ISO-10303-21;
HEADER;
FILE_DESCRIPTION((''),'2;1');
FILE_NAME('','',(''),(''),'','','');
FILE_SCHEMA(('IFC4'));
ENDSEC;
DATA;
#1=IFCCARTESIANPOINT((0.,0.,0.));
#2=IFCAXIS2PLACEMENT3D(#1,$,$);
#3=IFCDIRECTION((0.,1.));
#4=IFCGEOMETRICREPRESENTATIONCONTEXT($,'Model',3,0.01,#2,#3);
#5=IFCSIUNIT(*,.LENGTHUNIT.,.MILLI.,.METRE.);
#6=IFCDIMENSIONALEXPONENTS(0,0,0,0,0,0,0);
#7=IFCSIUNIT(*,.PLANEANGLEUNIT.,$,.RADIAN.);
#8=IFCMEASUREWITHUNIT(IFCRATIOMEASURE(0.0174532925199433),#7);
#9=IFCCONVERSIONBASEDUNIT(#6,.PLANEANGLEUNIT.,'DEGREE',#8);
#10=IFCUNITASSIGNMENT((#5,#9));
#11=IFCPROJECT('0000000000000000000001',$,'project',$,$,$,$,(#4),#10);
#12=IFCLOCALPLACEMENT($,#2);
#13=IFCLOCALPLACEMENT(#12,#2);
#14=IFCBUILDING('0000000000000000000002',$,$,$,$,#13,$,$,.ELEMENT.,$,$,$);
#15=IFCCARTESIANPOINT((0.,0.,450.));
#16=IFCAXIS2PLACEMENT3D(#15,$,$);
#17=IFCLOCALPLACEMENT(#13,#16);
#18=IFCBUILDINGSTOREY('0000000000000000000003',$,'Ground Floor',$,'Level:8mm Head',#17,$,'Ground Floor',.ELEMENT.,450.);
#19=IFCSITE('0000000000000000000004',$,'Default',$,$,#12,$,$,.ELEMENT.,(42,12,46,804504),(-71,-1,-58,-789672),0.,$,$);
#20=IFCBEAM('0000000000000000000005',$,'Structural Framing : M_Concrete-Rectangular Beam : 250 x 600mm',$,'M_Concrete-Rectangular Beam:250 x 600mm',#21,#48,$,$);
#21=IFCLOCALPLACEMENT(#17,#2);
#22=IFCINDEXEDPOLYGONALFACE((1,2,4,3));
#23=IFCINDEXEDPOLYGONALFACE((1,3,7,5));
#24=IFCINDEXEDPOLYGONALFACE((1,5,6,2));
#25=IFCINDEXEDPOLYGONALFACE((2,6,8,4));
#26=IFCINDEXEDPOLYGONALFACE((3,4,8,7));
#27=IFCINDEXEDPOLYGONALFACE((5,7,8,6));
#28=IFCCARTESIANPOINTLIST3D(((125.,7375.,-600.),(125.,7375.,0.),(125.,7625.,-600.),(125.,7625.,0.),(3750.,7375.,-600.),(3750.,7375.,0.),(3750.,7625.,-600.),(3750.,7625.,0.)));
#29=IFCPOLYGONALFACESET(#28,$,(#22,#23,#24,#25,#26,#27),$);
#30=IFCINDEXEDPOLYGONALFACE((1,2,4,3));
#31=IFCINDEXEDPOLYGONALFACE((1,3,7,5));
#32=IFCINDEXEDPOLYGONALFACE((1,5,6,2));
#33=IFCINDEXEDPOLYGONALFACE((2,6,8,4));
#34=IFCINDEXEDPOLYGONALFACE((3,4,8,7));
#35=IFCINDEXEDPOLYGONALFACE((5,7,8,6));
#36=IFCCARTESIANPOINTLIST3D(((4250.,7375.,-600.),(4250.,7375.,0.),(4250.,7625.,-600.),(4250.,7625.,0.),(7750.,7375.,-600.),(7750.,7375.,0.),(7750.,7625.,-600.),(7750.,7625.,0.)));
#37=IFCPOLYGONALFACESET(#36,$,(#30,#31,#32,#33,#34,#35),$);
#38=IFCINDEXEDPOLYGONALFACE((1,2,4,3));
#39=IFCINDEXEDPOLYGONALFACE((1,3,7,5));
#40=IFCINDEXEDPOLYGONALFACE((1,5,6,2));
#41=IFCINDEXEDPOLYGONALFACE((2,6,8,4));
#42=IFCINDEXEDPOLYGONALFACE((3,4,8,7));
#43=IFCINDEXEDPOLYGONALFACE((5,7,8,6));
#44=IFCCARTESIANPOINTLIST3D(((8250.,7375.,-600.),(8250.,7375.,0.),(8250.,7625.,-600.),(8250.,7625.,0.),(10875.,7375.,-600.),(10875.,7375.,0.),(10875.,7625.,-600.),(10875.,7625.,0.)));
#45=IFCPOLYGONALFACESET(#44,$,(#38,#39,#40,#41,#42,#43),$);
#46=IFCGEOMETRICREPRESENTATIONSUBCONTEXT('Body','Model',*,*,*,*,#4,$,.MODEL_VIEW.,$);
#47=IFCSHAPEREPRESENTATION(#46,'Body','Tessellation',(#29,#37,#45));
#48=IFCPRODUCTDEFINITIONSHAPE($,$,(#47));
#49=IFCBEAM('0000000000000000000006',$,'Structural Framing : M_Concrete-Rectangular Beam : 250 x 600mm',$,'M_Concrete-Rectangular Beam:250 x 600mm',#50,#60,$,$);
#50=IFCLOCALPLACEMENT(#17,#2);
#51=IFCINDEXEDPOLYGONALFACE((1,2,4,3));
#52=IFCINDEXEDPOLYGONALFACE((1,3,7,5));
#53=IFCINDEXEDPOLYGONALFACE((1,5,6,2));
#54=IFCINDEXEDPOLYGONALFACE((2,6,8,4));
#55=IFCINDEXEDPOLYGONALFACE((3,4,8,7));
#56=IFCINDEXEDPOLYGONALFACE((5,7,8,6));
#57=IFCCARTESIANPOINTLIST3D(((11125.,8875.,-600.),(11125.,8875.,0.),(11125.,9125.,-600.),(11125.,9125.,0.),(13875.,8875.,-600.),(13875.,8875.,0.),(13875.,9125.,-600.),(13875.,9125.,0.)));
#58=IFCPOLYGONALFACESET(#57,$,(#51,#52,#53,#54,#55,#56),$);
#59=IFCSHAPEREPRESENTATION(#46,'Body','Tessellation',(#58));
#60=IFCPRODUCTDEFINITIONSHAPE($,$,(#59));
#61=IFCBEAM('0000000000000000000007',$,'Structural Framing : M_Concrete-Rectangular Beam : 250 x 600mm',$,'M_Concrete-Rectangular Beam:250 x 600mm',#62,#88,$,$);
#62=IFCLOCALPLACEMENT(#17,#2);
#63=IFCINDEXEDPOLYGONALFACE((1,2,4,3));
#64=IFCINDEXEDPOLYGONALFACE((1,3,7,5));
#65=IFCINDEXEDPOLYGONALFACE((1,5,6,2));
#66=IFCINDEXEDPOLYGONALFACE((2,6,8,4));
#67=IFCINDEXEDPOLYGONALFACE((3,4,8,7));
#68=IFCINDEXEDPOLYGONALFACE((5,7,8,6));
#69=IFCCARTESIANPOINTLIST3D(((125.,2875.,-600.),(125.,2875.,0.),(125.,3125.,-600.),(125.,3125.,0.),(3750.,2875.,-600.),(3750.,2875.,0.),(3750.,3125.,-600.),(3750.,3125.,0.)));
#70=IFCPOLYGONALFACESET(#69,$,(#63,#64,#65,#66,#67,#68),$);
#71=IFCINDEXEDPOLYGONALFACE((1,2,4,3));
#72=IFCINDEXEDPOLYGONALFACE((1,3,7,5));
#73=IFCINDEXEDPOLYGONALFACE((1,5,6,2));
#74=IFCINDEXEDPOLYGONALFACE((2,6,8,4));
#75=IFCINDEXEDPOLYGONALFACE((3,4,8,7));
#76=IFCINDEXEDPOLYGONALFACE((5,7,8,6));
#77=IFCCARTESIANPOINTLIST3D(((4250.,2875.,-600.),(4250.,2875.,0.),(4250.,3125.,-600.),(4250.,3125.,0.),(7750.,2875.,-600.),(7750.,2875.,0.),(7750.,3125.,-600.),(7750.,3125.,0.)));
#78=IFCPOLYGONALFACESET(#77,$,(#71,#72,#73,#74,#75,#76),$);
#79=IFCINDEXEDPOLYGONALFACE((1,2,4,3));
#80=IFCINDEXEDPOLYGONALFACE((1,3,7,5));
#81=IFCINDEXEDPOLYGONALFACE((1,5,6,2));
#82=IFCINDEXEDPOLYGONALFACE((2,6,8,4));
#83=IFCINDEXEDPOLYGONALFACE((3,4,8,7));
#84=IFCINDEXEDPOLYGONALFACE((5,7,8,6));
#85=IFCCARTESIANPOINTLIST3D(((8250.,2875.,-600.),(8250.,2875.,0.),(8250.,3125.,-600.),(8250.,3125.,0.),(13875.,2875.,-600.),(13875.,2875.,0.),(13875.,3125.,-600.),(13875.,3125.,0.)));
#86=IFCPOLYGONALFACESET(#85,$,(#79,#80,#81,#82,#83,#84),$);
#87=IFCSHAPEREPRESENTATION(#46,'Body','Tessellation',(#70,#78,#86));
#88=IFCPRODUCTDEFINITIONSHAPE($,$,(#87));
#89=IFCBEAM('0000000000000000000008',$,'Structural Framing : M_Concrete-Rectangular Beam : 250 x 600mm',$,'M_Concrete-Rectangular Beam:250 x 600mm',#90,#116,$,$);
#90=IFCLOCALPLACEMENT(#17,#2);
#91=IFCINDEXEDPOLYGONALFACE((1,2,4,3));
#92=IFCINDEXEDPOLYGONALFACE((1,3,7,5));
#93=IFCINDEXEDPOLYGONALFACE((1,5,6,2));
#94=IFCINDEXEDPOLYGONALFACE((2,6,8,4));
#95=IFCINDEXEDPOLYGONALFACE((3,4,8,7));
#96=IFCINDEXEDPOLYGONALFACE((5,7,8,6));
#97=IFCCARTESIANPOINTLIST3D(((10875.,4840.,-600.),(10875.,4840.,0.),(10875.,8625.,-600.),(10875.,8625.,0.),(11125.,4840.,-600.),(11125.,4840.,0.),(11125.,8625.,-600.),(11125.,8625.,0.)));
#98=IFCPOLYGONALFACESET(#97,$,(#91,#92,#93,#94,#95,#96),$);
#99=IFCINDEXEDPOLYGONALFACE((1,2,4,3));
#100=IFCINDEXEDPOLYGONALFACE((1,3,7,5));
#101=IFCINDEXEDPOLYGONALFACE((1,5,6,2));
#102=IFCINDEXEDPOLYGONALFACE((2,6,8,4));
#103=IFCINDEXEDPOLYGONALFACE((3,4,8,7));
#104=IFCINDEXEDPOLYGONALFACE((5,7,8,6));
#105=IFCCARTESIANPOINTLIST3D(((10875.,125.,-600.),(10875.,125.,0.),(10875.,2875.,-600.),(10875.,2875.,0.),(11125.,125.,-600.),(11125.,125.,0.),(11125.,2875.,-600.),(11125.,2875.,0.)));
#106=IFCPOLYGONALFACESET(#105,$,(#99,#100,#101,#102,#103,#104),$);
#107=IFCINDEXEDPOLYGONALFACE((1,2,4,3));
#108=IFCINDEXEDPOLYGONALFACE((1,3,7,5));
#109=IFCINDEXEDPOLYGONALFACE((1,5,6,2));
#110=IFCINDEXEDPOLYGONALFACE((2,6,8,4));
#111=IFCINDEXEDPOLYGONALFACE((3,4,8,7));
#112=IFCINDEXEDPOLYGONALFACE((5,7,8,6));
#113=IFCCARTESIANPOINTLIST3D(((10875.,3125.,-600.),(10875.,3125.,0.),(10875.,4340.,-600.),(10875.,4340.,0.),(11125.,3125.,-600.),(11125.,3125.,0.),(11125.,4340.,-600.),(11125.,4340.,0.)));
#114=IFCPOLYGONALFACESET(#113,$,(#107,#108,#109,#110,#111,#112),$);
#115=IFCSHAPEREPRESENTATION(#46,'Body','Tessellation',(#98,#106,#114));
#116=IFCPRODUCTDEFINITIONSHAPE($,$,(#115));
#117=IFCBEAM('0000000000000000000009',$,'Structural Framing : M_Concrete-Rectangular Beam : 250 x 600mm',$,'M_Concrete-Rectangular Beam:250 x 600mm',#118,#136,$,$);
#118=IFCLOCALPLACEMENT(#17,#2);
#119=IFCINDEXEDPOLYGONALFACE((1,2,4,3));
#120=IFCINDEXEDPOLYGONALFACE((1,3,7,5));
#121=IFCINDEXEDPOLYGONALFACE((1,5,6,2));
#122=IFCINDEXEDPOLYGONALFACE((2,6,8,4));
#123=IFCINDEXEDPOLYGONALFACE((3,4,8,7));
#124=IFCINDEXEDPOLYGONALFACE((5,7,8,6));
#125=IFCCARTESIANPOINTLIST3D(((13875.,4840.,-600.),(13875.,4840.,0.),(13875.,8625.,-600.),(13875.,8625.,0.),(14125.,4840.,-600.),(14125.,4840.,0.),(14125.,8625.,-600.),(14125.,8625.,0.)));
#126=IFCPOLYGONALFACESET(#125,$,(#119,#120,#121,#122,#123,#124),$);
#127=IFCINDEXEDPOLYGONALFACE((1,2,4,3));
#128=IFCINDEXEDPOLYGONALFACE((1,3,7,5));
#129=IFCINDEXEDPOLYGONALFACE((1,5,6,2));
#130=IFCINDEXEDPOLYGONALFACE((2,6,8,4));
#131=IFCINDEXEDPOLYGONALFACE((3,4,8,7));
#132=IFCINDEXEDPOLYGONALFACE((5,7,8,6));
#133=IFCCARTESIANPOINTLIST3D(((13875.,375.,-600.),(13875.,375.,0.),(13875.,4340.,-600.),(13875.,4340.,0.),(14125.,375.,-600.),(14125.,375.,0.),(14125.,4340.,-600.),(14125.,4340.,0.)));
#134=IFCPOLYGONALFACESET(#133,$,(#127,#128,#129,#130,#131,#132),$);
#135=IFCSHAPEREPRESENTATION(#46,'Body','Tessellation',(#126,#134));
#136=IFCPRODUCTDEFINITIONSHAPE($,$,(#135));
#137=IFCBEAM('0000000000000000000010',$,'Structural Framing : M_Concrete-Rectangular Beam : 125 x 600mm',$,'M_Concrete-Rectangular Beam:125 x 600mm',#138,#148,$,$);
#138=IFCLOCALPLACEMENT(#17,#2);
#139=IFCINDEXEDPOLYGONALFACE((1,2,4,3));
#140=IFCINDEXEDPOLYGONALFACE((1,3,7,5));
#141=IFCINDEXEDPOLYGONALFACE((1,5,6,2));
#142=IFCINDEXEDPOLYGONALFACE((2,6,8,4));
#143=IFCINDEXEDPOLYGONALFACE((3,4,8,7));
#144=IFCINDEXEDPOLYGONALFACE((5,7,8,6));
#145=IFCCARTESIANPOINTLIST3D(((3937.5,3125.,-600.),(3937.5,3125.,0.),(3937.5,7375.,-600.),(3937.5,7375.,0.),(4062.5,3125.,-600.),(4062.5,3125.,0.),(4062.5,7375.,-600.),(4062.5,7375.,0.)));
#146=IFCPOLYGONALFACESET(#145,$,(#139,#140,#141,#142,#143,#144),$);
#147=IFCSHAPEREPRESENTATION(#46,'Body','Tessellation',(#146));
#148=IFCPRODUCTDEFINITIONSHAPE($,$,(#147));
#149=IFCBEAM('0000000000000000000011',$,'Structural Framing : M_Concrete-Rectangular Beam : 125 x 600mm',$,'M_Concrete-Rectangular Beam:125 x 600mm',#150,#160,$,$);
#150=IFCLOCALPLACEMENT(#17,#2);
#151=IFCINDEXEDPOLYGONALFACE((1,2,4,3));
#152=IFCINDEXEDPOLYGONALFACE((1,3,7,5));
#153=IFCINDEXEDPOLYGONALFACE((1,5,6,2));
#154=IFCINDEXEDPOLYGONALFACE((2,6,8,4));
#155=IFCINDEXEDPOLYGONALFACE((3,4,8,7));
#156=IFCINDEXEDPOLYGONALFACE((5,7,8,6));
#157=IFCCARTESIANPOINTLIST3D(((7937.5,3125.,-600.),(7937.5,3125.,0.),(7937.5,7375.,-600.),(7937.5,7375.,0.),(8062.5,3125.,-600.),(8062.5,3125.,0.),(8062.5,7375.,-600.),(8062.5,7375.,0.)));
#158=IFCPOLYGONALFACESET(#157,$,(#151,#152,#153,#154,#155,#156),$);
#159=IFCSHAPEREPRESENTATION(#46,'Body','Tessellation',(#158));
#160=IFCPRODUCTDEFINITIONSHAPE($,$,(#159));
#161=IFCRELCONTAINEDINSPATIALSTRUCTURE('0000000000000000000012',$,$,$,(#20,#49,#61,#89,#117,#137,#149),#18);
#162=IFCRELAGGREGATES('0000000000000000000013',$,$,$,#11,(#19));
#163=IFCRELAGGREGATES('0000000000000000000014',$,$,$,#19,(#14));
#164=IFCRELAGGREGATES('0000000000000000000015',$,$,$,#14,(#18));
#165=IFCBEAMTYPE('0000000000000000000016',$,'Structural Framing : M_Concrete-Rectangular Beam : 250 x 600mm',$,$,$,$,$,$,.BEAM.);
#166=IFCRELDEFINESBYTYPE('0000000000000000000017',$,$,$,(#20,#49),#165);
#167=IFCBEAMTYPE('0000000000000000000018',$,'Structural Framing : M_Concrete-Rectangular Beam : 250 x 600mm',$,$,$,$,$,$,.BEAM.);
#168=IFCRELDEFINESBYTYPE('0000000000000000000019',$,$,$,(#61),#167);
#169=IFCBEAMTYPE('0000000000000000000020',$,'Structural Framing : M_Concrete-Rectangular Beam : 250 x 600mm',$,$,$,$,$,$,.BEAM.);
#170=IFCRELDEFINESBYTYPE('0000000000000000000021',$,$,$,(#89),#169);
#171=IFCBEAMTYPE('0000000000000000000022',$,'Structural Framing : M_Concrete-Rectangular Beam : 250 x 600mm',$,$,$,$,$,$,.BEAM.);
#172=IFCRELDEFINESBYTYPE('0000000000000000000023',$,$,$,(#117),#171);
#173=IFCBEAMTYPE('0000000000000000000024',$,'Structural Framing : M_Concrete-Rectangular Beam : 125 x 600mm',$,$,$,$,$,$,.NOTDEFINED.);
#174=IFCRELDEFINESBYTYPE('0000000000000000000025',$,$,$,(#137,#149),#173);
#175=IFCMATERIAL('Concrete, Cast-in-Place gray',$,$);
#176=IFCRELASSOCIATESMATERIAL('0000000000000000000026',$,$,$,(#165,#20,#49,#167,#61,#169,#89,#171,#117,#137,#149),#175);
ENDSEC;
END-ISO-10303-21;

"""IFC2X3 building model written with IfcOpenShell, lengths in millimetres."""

from ifc_helpers import new_model, entity, si_unit, converted_unit, direction, frame, frame_2d, origin, place, context, subcontext, project, spatial, rectangle, extrude, source, transform, mapped, material, type_object, type_shapes, element, save


model = new_model("IFC2X3")

# Units and contexts
model_context = context("Model", 3, precision=0.01, world=origin(), true_north=direction((0.0, 1.0)))
body_context = subcontext(model_context, "Body", "Model", "MODEL_VIEW")
ifc_project = project(units=[si_unit("LENGTHUNIT", "METRE", prefix="MILLI"), converted_unit("PLANEANGLEUNIT", "DEGREE", entity("IfcRatioMeasure", 0.0174532925199433), si_unit("PLANEANGLEUNIT", "RADIAN"), dimensions=[0, 0, 0, 0, 0, 0, 0])], contexts=[model_context])

# Site, building, storey
site_placement = place(None, origin())
site = spatial("IfcSite", under=ifc_project, at=site_placement, Name="Default", CompositionType="ELEMENT", RefLatitude=(42, 12, 46, 804504), RefLongitude=(-71, -1, -58, -789672), RefElevation=0.0)
building_placement = place(site_placement, origin())
building = spatial("IfcBuilding", under=site, at=building_placement, CompositionType="ELEMENT")
storey_placement = place(building_placement, frame((0.0, 0.0, 450.0)))
storey = spatial("IfcBuildingStorey", under=building, at=storey_placement, Name="Ground Floor", ObjectType="Level:8mm Head", LongName="Ground Floor", CompositionType="ELEMENT", Elevation=450.0)

# Shared definitions
ifc_material = material(Name="Concrete, Cast-in-Place gray")

# Beams
beam_type_1 = type_object("IfcBeamType", Name="Structural Framing : M_Concrete-Rectangular Beam : 250 x 600mm", PredefinedType="BEAM", material=ifc_material)
shared_shape_1 = source(origin(), body_context, "Body", "SweptSolid", [
    extrude(rectangle(XDim=600.0, YDim=250.0, at=frame_2d((0.0, 0.0), x_axis=(1.0, 0.0))), frame((125.0, 7500.0, 150.0), z_axis=(1.0, 0.0, 0.0), x_axis=(0.0, 0.0, -1.0)), (0.0, 0.0, 1.0), 3625.0),
    extrude(rectangle(XDim=600.0, YDim=250.0, at=frame_2d((0.0, 0.0), x_axis=(1.0, 0.0))), frame((4250.0, 7500.0, 150.0), z_axis=(1.0, 0.0, 0.0), x_axis=(0.0, 0.0, -1.0)), (0.0, 0.0, 1.0), 3500.0),
    extrude(rectangle(XDim=600.0, YDim=250.0, at=frame_2d((0.0, 0.0), x_axis=(1.0, 0.0))), frame((8250.0, 7500.0, 150.0), z_axis=(1.0, 0.0, 0.0), x_axis=(0.0, 0.0, -1.0)), (0.0, 0.0, 1.0), 2625.0),
])
type_shapes(beam_type_1, [shared_shape_1])
beam_1_placement = place(storey_placement, frame((0.0, 0.0, -450.0)))
element("IfcBeam", 1, at=beam_1_placement, inside=storey, type_object=beam_type_1, material=ifc_material, Name="Structural Framing : M_Concrete-Rectangular Beam : 250 x 600mm", ObjectType="M_Concrete-Rectangular Beam:250 x 600mm", context=body_context, shape_type="MappedRepresentation", body=[
    mapped(shared_shape_1, transform((0.0, 0.0, 0.0), scale=1.0)),
])
beam_2_placement = place(storey_placement, frame((11000.0, 9000.0, 0.0)))
element("IfcBeam", 2, at=beam_2_placement, inside=storey, type_object=beam_type_1, material=ifc_material, Name="Structural Framing : M_Concrete-Rectangular Beam : 250 x 600mm", ObjectType="M_Concrete-Rectangular Beam:250 x 600mm", context=body_context, shape_type="SweptSolid", body=[
    extrude(rectangle(XDim=600.0, YDim=250.0, at=frame_2d((0.0, 0.0), x_axis=(1.0, 0.0))), frame((125.0, 0.0, -300.0), z_axis=(1.0, 0.0, 0.0), x_axis=(0.0, 0.0, -1.0)), (0.0, 0.0, 1.0), 2750.0),
])
beam_type_2 = type_object("IfcBeamType", Name="Structural Framing : M_Concrete-Rectangular Beam : 250 x 600mm", PredefinedType="BEAM", material=ifc_material)
shared_shape_2 = source(origin(), body_context, "Body", "SweptSolid", [
    extrude(rectangle(XDim=600.0, YDim=250.0, at=frame_2d((0.0, 0.0), x_axis=(1.0, 0.0))), frame((125.0, 3000.0, 150.0), z_axis=(1.0, 0.0, 0.0), x_axis=(0.0, 0.0, -1.0)), (0.0, 0.0, 1.0), 3625.0),
    extrude(rectangle(XDim=600.0, YDim=250.0, at=frame_2d((0.0, 0.0), x_axis=(1.0, 0.0))), frame((4250.0, 3000.0, 150.0), z_axis=(1.0, 0.0, 0.0), x_axis=(0.0, 0.0, -1.0)), (0.0, 0.0, 1.0), 3500.0),
    extrude(rectangle(XDim=600.0, YDim=250.0, at=frame_2d((0.0, 0.0), x_axis=(1.0, 0.0))), frame((8250.0, 3000.0, 150.0), z_axis=(1.0, 0.0, 0.0), x_axis=(0.0, 0.0, -1.0)), (0.0, 0.0, 1.0), 5625.0),
])
type_shapes(beam_type_2, [shared_shape_2])
beam_3_placement = place(storey_placement, frame((0.0, 0.0, -450.0)))
element("IfcBeam", 3, at=beam_3_placement, inside=storey, type_object=beam_type_2, material=ifc_material, Name="Structural Framing : M_Concrete-Rectangular Beam : 250 x 600mm", ObjectType="M_Concrete-Rectangular Beam:250 x 600mm", context=body_context, shape_type="MappedRepresentation", body=[
    mapped(shared_shape_2, transform((0.0, 0.0, 0.0), scale=1.0)),
])
beam_type_3 = type_object("IfcBeamType", Name="Structural Framing : M_Concrete-Rectangular Beam : 250 x 600mm", PredefinedType="BEAM", material=ifc_material)
shared_shape_3 = source(origin(), body_context, "Body", "SweptSolid", [
    extrude(rectangle(XDim=600.0, YDim=250.0, at=frame_2d((0.0, 0.0), x_axis=(0.0, 1.0))), frame((11000.0, 4840.0, 150.0), z_axis=(0.0, 1.0, 0.0), x_axis=(-1.0, 0.0, 0.0)), (0.0, 0.0, 1.0), 3785.0),
    extrude(rectangle(XDim=600.0, YDim=250.0, at=frame_2d((0.0, 0.0), x_axis=(0.0, 1.0))), frame((11000.0, 125.0, 150.0), z_axis=(0.0, 1.0, 0.0), x_axis=(-1.0, 0.0, 0.0)), (0.0, 0.0, 1.0), 2750.0),
    extrude(rectangle(XDim=600.0, YDim=250.0, at=frame_2d((0.0, 0.0), x_axis=(0.0, 1.0))), frame((11000.0, 3125.0, 150.0), z_axis=(0.0, 1.0, 0.0), x_axis=(-1.0, 0.0, 0.0)), (0.0, 0.0, 1.0), 1215.0),
])
type_shapes(beam_type_3, [shared_shape_3])
beam_4_placement = place(storey_placement, frame((0.0, 0.0, -450.0)))
element("IfcBeam", 4, at=beam_4_placement, inside=storey, type_object=beam_type_3, material=ifc_material, Name="Structural Framing : M_Concrete-Rectangular Beam : 250 x 600mm", ObjectType="M_Concrete-Rectangular Beam:250 x 600mm", context=body_context, shape_type="MappedRepresentation", body=[
    mapped(shared_shape_3, transform((0.0, 0.0, 0.0), scale=1.0)),
])
beam_type_4 = type_object("IfcBeamType", Name="Structural Framing : M_Concrete-Rectangular Beam : 250 x 600mm", PredefinedType="BEAM", material=ifc_material)
shared_shape_4 = source(origin(), body_context, "Body", "SweptSolid", [
    extrude(rectangle(XDim=600.0, YDim=250.0, at=frame_2d((0.0, 0.0), x_axis=(0.0, 1.0))), frame((14000.0, 8625.0, 150.0), z_axis=(0.0, -1.0, 0.0), x_axis=(-1.0, 0.0, 0.0)), (0.0, 0.0, 1.0), 3785.0),
    extrude(rectangle(XDim=600.0, YDim=250.0, at=frame_2d((0.0, 0.0), x_axis=(0.0, 1.0))), frame((14000.0, 4340.0, 150.0), z_axis=(0.0, -1.0, 0.0), x_axis=(-1.0, 0.0, 0.0)), (0.0, 0.0, 1.0), 3965.0),
])
type_shapes(beam_type_4, [shared_shape_4])
beam_5_placement = place(storey_placement, frame((0.0, 0.0, -450.0)))
element("IfcBeam", 5, at=beam_5_placement, inside=storey, type_object=beam_type_4, material=ifc_material, Name="Structural Framing : M_Concrete-Rectangular Beam : 250 x 600mm", ObjectType="M_Concrete-Rectangular Beam:250 x 600mm", context=body_context, shape_type="MappedRepresentation", body=[
    mapped(shared_shape_4, transform((0.0, 0.0, 0.0), scale=1.0)),
])
beam_type_5 = type_object("IfcBeamType", Name="Structural Framing : M_Concrete-Rectangular Beam : 125 x 600mm", PredefinedType="NOTDEFINED")
beam_6_placement = place(storey_placement, frame((4000.0, 3000.0, 0.0), z_axis=(0.0, 0.0, 1.0), x_axis=(0.0, 1.0, 0.0)))
element("IfcBeam", 6, at=beam_6_placement, inside=storey, type_object=beam_type_5, material=ifc_material, Name="Structural Framing : M_Concrete-Rectangular Beam : 125 x 600mm", ObjectType="M_Concrete-Rectangular Beam:125 x 600mm", context=body_context, shape_type="SweptSolid", body=[
    extrude(rectangle(XDim=600.0, YDim=125.0, at=frame_2d((0.0, 0.0), x_axis=(1.0, 0.0))), frame((125.0, 0.0, -300.0), z_axis=(1.0, 0.0, 0.0), x_axis=(0.0, 0.0, -1.0)), (0.0, 0.0, 1.0), 4250.0),
])
beam_7_placement = place(storey_placement, frame((8000.0, 3000.0, 0.0), z_axis=(0.0, 0.0, 1.0), x_axis=(0.0, 1.0, 0.0)))
element("IfcBeam", 7, at=beam_7_placement, inside=storey, type_object=beam_type_5, material=ifc_material, Name="Structural Framing : M_Concrete-Rectangular Beam : 125 x 600mm", ObjectType="M_Concrete-Rectangular Beam:125 x 600mm", context=body_context, shape_type="SweptSolid", body=[
    extrude(rectangle(XDim=600.0, YDim=125.0, at=frame_2d((0.0, 0.0), x_axis=(1.0, 0.0))), frame((125.0, 0.0, -300.0), z_axis=(1.0, 0.0, 0.0), x_axis=(0.0, 0.0, -1.0)), (0.0, 0.0, 1.0), 4250.0),
])

save(model, "model.ifc")
